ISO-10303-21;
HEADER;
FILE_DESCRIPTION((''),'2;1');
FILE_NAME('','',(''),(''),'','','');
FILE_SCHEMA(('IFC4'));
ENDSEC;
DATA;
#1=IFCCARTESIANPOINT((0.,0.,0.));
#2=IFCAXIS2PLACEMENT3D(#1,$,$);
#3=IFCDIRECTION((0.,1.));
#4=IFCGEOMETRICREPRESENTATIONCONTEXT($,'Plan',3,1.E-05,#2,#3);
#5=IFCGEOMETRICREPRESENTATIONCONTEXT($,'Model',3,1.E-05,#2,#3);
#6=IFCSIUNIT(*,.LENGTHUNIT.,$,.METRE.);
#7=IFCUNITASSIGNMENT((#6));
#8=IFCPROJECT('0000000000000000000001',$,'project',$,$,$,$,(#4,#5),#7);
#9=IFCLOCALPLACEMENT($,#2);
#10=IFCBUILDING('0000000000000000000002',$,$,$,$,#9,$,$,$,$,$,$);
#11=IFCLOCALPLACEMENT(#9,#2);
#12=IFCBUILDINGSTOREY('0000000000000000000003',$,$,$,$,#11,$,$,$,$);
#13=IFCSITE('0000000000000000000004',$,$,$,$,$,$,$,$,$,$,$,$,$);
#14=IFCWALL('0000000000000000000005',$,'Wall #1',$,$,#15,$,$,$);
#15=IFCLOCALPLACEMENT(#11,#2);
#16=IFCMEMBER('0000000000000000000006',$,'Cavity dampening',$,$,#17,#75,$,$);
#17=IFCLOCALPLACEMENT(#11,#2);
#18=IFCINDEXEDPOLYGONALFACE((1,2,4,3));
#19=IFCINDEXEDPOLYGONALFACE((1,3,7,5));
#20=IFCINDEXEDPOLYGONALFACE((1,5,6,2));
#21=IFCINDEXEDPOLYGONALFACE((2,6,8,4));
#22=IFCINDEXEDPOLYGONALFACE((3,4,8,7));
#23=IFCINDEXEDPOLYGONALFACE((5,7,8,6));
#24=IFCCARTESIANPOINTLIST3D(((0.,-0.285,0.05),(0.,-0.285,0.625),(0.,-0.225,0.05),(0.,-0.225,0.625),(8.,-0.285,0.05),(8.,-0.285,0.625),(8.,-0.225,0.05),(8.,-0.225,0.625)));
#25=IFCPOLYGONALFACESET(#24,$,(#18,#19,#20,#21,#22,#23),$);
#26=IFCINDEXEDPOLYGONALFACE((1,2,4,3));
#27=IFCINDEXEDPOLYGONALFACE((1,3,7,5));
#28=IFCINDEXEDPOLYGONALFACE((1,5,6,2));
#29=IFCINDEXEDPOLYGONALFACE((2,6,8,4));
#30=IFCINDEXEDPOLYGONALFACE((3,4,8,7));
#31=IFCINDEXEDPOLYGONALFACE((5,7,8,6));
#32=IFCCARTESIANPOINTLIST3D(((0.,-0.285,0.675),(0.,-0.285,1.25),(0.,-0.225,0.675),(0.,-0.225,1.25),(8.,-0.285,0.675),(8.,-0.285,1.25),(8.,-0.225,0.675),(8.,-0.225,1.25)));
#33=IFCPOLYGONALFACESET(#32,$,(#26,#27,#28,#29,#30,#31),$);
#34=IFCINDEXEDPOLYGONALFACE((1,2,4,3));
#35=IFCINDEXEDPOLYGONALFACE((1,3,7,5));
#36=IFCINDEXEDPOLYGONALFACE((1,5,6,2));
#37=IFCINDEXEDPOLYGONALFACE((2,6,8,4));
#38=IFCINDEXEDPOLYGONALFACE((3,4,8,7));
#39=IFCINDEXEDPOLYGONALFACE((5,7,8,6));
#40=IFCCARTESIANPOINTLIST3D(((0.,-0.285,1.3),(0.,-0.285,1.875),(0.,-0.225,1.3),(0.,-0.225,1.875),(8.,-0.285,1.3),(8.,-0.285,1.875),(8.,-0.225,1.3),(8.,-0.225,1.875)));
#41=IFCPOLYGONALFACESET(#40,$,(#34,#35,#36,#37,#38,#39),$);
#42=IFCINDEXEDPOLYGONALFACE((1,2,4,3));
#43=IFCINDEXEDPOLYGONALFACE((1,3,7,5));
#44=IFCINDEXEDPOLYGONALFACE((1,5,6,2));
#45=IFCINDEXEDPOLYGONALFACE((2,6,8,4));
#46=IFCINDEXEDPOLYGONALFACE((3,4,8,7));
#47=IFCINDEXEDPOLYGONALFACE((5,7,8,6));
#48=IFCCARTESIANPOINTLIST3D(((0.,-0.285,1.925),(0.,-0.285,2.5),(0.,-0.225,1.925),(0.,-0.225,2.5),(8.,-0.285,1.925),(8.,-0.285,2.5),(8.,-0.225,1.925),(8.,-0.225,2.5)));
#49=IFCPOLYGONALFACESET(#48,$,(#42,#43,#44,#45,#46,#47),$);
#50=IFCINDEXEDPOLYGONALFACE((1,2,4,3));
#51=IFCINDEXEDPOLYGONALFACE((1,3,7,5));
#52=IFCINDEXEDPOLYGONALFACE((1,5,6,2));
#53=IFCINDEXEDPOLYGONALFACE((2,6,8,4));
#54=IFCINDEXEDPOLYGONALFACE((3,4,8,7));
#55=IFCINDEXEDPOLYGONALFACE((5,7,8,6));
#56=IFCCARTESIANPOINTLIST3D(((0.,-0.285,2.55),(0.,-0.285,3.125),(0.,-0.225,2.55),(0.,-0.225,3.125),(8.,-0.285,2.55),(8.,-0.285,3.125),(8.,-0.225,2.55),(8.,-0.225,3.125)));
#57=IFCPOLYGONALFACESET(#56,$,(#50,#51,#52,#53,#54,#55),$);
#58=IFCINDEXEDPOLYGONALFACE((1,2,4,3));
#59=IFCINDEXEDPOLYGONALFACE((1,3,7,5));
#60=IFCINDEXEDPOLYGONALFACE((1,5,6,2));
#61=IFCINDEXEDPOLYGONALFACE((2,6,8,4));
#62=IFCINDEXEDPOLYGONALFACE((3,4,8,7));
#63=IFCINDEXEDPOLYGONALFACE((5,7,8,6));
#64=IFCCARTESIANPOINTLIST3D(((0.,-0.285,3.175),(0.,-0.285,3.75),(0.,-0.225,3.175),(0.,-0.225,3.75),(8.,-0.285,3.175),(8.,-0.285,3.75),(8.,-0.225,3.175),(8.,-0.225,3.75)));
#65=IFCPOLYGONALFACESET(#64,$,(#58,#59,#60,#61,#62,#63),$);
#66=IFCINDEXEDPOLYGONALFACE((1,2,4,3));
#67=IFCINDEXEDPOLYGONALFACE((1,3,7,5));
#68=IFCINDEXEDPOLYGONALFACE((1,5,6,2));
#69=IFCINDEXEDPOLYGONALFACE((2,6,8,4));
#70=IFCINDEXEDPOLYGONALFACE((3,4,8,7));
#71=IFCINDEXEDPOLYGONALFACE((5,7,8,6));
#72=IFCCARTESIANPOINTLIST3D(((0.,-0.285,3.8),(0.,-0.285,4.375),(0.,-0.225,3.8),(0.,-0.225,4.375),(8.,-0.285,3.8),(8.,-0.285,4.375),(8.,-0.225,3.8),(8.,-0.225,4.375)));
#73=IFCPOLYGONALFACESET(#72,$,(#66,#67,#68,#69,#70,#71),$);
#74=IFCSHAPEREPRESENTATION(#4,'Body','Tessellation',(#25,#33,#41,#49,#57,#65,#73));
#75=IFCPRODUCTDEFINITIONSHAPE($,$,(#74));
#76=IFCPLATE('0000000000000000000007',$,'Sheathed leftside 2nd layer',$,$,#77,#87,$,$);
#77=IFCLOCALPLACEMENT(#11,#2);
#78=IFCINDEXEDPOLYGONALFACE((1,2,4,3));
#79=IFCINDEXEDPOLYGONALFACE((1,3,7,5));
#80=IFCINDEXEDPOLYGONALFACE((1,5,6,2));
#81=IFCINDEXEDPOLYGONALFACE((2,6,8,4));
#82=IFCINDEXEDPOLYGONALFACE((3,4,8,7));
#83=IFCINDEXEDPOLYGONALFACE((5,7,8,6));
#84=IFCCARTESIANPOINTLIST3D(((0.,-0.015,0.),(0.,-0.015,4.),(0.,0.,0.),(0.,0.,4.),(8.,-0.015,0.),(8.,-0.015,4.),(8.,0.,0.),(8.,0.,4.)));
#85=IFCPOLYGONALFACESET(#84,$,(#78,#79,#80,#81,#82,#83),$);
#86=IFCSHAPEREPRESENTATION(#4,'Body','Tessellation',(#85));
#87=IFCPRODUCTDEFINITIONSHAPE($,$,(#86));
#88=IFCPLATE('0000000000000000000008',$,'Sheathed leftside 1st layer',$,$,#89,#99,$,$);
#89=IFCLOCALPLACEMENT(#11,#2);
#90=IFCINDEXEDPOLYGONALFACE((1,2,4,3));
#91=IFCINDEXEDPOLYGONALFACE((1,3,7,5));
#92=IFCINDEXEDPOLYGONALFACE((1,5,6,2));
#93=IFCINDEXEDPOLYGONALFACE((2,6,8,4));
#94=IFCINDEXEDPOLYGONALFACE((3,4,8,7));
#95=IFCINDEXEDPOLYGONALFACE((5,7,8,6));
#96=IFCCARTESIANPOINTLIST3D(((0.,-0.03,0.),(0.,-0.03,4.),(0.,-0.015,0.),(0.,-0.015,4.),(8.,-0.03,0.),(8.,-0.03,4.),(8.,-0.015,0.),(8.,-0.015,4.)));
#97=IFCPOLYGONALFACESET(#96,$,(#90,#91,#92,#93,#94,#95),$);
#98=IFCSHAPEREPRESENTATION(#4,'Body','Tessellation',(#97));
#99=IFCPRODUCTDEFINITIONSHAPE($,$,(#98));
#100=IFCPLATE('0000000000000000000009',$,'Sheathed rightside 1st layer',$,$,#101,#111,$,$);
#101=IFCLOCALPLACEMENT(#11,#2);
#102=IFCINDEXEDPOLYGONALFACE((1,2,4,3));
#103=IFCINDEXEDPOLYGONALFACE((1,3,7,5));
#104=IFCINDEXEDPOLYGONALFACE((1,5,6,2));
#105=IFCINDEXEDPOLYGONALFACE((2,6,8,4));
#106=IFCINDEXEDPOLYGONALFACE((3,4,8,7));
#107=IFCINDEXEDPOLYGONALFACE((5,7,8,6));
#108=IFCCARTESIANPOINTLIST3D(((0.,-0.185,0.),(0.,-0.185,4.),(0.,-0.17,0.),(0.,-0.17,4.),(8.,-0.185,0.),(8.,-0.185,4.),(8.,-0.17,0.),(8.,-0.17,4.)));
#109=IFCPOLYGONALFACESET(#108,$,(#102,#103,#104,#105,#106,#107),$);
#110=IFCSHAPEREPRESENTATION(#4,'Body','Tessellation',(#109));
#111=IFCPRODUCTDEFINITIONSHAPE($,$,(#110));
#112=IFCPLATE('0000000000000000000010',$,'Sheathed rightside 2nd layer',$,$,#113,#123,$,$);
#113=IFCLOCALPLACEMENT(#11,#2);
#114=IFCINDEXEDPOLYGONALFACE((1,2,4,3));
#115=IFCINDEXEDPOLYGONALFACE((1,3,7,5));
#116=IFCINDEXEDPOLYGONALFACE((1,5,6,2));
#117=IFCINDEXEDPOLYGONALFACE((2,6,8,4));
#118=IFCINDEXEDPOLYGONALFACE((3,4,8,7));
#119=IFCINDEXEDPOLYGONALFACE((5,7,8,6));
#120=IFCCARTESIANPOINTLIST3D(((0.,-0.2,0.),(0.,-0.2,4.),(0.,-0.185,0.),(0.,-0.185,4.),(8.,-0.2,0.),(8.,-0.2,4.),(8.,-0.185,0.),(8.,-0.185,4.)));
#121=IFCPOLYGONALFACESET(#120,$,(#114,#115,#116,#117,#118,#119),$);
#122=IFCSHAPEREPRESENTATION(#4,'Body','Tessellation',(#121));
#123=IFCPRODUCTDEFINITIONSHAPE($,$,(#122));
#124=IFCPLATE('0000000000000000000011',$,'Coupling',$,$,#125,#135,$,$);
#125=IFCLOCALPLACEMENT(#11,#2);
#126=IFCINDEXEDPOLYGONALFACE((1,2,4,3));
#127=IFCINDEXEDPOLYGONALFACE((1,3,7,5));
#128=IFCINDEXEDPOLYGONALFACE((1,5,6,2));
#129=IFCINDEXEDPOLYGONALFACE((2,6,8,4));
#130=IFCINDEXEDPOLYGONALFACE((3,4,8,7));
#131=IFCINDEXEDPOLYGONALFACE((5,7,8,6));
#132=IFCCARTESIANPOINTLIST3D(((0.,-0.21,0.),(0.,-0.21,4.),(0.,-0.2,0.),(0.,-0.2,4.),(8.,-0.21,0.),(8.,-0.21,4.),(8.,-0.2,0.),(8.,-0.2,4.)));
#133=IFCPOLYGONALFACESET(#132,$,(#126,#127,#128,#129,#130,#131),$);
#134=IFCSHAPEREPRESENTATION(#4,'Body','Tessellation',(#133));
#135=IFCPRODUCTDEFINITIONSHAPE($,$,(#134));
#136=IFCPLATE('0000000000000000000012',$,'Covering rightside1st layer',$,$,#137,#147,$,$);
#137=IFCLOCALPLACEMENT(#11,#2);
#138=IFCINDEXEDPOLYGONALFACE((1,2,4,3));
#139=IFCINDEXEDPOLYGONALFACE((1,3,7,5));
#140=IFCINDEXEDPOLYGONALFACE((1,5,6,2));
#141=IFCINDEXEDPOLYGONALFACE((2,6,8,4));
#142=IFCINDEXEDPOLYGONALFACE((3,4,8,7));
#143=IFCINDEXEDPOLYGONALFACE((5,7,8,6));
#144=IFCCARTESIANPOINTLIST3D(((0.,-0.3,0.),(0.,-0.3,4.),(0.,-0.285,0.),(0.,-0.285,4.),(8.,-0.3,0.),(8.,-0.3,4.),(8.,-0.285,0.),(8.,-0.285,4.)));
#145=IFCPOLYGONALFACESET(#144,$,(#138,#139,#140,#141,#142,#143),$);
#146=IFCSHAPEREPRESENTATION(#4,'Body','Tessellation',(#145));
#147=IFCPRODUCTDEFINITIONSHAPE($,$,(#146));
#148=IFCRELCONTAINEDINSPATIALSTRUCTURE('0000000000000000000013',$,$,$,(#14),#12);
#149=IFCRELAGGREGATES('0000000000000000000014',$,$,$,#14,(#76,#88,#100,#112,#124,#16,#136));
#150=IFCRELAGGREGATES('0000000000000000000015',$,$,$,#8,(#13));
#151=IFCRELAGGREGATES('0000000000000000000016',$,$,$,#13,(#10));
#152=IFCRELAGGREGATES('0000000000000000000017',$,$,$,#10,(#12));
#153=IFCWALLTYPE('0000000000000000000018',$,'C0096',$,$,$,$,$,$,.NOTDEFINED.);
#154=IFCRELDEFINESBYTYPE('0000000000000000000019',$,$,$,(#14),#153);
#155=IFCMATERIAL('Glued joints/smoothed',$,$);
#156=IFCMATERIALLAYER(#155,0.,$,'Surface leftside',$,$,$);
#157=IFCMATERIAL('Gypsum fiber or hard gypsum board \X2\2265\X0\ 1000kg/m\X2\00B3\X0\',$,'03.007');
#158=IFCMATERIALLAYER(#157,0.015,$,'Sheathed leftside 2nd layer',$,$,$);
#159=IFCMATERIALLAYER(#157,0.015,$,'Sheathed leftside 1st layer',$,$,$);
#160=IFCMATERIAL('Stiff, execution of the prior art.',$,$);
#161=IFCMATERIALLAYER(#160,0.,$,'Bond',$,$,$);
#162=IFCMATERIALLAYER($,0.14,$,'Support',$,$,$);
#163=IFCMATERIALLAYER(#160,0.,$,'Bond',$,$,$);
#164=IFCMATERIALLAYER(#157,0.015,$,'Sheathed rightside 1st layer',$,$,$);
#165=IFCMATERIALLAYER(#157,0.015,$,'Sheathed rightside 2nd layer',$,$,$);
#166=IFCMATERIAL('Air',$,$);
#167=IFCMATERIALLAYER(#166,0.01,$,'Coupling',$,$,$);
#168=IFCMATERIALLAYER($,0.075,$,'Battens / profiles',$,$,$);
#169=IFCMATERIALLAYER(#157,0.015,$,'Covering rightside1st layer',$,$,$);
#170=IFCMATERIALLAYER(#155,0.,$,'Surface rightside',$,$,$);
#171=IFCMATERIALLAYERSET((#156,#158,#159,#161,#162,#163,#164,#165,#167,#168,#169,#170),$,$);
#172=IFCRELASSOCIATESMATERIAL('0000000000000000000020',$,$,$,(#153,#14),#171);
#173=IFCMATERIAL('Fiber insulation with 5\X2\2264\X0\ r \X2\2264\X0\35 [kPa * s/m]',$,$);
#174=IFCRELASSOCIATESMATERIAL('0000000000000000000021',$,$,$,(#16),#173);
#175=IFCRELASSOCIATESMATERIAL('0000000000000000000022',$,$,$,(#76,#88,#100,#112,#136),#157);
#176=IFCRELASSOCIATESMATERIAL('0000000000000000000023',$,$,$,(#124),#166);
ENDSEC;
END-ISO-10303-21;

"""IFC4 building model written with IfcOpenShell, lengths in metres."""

from ifc_helpers import new_model, si_unit, direction, frame, frame_2d, origin, origin_with_axes, place, context, project, spatial, rectangle, extrude, material, layer, layer_set, type_object, element, aggregate, save


model = new_model("IFC4")

# Units and contexts
plan_context = context("Plan", 3, precision=1e-05, world=origin(), true_north=direction((0.0, 1.0)))
model_context = context("Model", 3, precision=1e-05, world=origin(), true_north=direction((0.0, 1.0)))
ifc_project = project(units=[si_unit("LENGTHUNIT", "METRE")], contexts=[plan_context, model_context])

# Site, building, storey
site = spatial("IfcSite", under=ifc_project)
building_placement = place(None, origin())
building = spatial("IfcBuilding", under=site, at=building_placement)
storey_placement = place(building_placement, origin())
storey = spatial("IfcBuildingStorey", under=building, at=storey_placement)

# Wall, member, plates
ifc_material_1 = material(Name="Glued joints/smoothed")
ifc_layer_1 = layer(ifc_material_1, 0.0, Name="Surface leftside")
ifc_material_2 = material(Name="Gypsum fiber or hard gypsum board ≥ 1000kg/m³", Category="03.007")
ifc_layer_2 = layer(ifc_material_2, 0.015, Name="Sheathed leftside 2nd layer")
ifc_layer_3 = layer(ifc_material_2, 0.015, Name="Sheathed leftside 1st layer")
ifc_material_3 = material(Name="Stiff, execution of the prior art.")
ifc_layer_4 = layer(ifc_material_3, 0.0, Name="Bond")
ifc_layer_5 = layer(None, 0.14, Name="Support")
ifc_layer_6 = layer(ifc_material_3, 0.0, Name="Bond")
ifc_layer_7 = layer(ifc_material_2, 0.015, Name="Sheathed rightside 1st layer")
ifc_layer_8 = layer(ifc_material_2, 0.015, Name="Sheathed rightside 2nd layer")
ifc_material_4 = material(Name="Air")
ifc_layer_9 = layer(ifc_material_4, 0.01, Name="Coupling")
ifc_layer_10 = layer(None, 0.075, Name="Battens / profiles")
ifc_layer_11 = layer(ifc_material_2, 0.015, Name="Covering rightside1st layer")
ifc_layer_12 = layer(ifc_material_1, 0.0, Name="Surface rightside")
ifc_layer_set = layer_set([ifc_layer_1, ifc_layer_2, ifc_layer_3, ifc_layer_4, ifc_layer_5, ifc_layer_6, ifc_layer_7, ifc_layer_8, ifc_layer_9, ifc_layer_10, ifc_layer_11, ifc_layer_12])
wall_type = type_object("IfcWallType", Name="C0096", PredefinedType="NOTDEFINED", material=ifc_layer_set)
wall_placement = place(None, frame((0.0, 0.0, 0.0), z_axis=(0.0, -1.0, 0.0), x_axis=(1.0, 0.0, 0.0)))
wall = element("IfcWall", 1, at=wall_placement, inside=storey, type_object=wall_type, material=ifc_layer_set, Name="Wall #1")
ifc_material_5 = material(Name="Fiber insulation with 5≤ r ≤35 [kPa * s/m]")
member_1_placement = place(wall_placement, origin())
member_1 = element("IfcMember", 2, at=member_1_placement, material=ifc_material_5, Name="Cavity dampening", context=plan_context, shape_type="SweptSolid", body=[
    extrude(rectangle(XDim=0.575, YDim=0.06, at=frame_2d((0.2875, 0.03), x_axis=(1.0, 0.0))), frame((0.0, 0.05, 0.225), z_axis=(1.0, 0.0, 0.0), x_axis=(0.0, 1.0, 0.0)), (0.0, 0.0, 1.0), 8.0),
    extrude(rectangle(XDim=0.575, YDim=0.06, at=frame_2d((0.2875, 0.03), x_axis=(1.0, 0.0))), frame((0.0, 0.675, 0.225), z_axis=(1.0, 0.0, 0.0), x_axis=(0.0, 1.0, 0.0)), (0.0, 0.0, 1.0), 8.0),
    extrude(rectangle(XDim=0.575, YDim=0.06, at=frame_2d((0.2875, 0.03), x_axis=(1.0, 0.0))), frame((0.0, 1.3, 0.225), z_axis=(1.0, 0.0, 0.0), x_axis=(0.0, 1.0, 0.0)), (0.0, 0.0, 1.0), 8.0),
    extrude(rectangle(XDim=0.575, YDim=0.06, at=frame_2d((0.2875, 0.03), x_axis=(1.0, 0.0))), frame((0.0, 1.925, 0.225), z_axis=(1.0, 0.0, 0.0), x_axis=(0.0, 1.0, 0.0)), (0.0, 0.0, 1.0), 8.0),
    extrude(rectangle(XDim=0.575, YDim=0.06, at=frame_2d((0.2875, 0.03), x_axis=(1.0, 0.0))), frame((0.0, 2.55, 0.225), z_axis=(1.0, 0.0, 0.0), x_axis=(0.0, 1.0, 0.0)), (0.0, 0.0, 1.0), 8.0),
    extrude(rectangle(XDim=0.575, YDim=0.06, at=frame_2d((0.2875, 0.03), x_axis=(1.0, 0.0))), frame((0.0, 3.175, 0.225), z_axis=(1.0, 0.0, 0.0), x_axis=(0.0, 1.0, 0.0)), (0.0, 0.0, 1.0), 8.0),
    extrude(rectangle(XDim=0.575, YDim=0.06, at=frame_2d((0.2875, 0.03), x_axis=(1.0, 0.0))), frame((0.0, 3.8, 0.225), z_axis=(1.0, 0.0, 0.0), x_axis=(0.0, 1.0, 0.0)), (0.0, 0.0, 1.0), 8.0),
])
plate_1_placement = place(wall_placement, origin())
plate_1 = element("IfcPlate", 3, at=plate_1_placement, material=ifc_material_2, Name="Sheathed leftside 2nd layer", context=plan_context, shape_type="SweptSolid", body=[
    extrude(rectangle(XDim=8.0, YDim=4.0, at=frame_2d((4.0, 2.0), x_axis=(1.0, 0.0))), origin_with_axes(), (0.0, 0.0, 1.0), 0.015),
])
plate_2_placement = place(wall_placement, origin())
plate_2 = element("IfcPlate", 4, at=plate_2_placement, material=ifc_material_2, Name="Sheathed leftside 1st layer", context=plan_context, shape_type="SweptSolid", body=[
    extrude(rectangle(XDim=8.0, YDim=4.0, at=frame_2d((4.0, 2.0), x_axis=(1.0, 0.0))), frame((0.0, 0.0, 0.015), z_axis=(0.0, 0.0, 1.0), x_axis=(1.0, 0.0, 0.0)), (0.0, 0.0, 1.0), 0.015),
])
plate_3_placement = place(wall_placement, origin())
plate_3 = element("IfcPlate", 5, at=plate_3_placement, material=ifc_material_2, Name="Sheathed rightside 1st layer", context=plan_context, shape_type="SweptSolid", body=[
    extrude(rectangle(XDim=8.0, YDim=4.0, at=frame_2d((4.0, 2.0), x_axis=(1.0, 0.0))), frame((0.0, 0.0, 0.17), z_axis=(0.0, 0.0, 1.0), x_axis=(1.0, 0.0, 0.0)), (0.0, 0.0, 1.0), 0.015),
])
plate_4_placement = place(wall_placement, origin())
plate_4 = element("IfcPlate", 6, at=plate_4_placement, material=ifc_material_2, Name="Sheathed rightside 2nd layer", context=plan_context, shape_type="SweptSolid", body=[
    extrude(rectangle(XDim=8.0, YDim=4.0, at=frame_2d((4.0, 2.0), x_axis=(1.0, 0.0))), frame((0.0, 0.0, 0.185), z_axis=(0.0, 0.0, 1.0), x_axis=(1.0, 0.0, 0.0)), (0.0, 0.0, 1.0), 0.015),
])
plate_5_placement = place(wall_placement, origin())
plate_5 = element("IfcPlate", 7, at=plate_5_placement, material=ifc_material_4, Name="Coupling", context=plan_context, shape_type="SweptSolid", body=[
    extrude(rectangle(XDim=8.0, YDim=4.0, at=frame_2d((4.0, 2.0), x_axis=(1.0, 0.0))), frame((0.0, 0.0, 0.2), z_axis=(0.0, 0.0, 1.0), x_axis=(1.0, 0.0, 0.0)), (0.0, 0.0, 1.0), 0.01),
])
plate_6_placement = place(wall_placement, origin())
plate_6 = element("IfcPlate", 8, at=plate_6_placement, material=ifc_material_2, Name="Covering rightside1st layer", context=plan_context, shape_type="SweptSolid", body=[
    extrude(rectangle(XDim=8.0, YDim=4.0, at=frame_2d((4.0, 2.0), x_axis=(1.0, 0.0))), frame((0.0, 0.0, 0.285), z_axis=(0.0, 0.0, 1.0), x_axis=(1.0, 0.0, 0.0)), (0.0, 0.0, 1.0), 0.015),
])
aggregate(wall, [plate_1, plate_2, plate_3, plate_4, plate_5, member_1, plate_6])

save(model, "model.ifc")
